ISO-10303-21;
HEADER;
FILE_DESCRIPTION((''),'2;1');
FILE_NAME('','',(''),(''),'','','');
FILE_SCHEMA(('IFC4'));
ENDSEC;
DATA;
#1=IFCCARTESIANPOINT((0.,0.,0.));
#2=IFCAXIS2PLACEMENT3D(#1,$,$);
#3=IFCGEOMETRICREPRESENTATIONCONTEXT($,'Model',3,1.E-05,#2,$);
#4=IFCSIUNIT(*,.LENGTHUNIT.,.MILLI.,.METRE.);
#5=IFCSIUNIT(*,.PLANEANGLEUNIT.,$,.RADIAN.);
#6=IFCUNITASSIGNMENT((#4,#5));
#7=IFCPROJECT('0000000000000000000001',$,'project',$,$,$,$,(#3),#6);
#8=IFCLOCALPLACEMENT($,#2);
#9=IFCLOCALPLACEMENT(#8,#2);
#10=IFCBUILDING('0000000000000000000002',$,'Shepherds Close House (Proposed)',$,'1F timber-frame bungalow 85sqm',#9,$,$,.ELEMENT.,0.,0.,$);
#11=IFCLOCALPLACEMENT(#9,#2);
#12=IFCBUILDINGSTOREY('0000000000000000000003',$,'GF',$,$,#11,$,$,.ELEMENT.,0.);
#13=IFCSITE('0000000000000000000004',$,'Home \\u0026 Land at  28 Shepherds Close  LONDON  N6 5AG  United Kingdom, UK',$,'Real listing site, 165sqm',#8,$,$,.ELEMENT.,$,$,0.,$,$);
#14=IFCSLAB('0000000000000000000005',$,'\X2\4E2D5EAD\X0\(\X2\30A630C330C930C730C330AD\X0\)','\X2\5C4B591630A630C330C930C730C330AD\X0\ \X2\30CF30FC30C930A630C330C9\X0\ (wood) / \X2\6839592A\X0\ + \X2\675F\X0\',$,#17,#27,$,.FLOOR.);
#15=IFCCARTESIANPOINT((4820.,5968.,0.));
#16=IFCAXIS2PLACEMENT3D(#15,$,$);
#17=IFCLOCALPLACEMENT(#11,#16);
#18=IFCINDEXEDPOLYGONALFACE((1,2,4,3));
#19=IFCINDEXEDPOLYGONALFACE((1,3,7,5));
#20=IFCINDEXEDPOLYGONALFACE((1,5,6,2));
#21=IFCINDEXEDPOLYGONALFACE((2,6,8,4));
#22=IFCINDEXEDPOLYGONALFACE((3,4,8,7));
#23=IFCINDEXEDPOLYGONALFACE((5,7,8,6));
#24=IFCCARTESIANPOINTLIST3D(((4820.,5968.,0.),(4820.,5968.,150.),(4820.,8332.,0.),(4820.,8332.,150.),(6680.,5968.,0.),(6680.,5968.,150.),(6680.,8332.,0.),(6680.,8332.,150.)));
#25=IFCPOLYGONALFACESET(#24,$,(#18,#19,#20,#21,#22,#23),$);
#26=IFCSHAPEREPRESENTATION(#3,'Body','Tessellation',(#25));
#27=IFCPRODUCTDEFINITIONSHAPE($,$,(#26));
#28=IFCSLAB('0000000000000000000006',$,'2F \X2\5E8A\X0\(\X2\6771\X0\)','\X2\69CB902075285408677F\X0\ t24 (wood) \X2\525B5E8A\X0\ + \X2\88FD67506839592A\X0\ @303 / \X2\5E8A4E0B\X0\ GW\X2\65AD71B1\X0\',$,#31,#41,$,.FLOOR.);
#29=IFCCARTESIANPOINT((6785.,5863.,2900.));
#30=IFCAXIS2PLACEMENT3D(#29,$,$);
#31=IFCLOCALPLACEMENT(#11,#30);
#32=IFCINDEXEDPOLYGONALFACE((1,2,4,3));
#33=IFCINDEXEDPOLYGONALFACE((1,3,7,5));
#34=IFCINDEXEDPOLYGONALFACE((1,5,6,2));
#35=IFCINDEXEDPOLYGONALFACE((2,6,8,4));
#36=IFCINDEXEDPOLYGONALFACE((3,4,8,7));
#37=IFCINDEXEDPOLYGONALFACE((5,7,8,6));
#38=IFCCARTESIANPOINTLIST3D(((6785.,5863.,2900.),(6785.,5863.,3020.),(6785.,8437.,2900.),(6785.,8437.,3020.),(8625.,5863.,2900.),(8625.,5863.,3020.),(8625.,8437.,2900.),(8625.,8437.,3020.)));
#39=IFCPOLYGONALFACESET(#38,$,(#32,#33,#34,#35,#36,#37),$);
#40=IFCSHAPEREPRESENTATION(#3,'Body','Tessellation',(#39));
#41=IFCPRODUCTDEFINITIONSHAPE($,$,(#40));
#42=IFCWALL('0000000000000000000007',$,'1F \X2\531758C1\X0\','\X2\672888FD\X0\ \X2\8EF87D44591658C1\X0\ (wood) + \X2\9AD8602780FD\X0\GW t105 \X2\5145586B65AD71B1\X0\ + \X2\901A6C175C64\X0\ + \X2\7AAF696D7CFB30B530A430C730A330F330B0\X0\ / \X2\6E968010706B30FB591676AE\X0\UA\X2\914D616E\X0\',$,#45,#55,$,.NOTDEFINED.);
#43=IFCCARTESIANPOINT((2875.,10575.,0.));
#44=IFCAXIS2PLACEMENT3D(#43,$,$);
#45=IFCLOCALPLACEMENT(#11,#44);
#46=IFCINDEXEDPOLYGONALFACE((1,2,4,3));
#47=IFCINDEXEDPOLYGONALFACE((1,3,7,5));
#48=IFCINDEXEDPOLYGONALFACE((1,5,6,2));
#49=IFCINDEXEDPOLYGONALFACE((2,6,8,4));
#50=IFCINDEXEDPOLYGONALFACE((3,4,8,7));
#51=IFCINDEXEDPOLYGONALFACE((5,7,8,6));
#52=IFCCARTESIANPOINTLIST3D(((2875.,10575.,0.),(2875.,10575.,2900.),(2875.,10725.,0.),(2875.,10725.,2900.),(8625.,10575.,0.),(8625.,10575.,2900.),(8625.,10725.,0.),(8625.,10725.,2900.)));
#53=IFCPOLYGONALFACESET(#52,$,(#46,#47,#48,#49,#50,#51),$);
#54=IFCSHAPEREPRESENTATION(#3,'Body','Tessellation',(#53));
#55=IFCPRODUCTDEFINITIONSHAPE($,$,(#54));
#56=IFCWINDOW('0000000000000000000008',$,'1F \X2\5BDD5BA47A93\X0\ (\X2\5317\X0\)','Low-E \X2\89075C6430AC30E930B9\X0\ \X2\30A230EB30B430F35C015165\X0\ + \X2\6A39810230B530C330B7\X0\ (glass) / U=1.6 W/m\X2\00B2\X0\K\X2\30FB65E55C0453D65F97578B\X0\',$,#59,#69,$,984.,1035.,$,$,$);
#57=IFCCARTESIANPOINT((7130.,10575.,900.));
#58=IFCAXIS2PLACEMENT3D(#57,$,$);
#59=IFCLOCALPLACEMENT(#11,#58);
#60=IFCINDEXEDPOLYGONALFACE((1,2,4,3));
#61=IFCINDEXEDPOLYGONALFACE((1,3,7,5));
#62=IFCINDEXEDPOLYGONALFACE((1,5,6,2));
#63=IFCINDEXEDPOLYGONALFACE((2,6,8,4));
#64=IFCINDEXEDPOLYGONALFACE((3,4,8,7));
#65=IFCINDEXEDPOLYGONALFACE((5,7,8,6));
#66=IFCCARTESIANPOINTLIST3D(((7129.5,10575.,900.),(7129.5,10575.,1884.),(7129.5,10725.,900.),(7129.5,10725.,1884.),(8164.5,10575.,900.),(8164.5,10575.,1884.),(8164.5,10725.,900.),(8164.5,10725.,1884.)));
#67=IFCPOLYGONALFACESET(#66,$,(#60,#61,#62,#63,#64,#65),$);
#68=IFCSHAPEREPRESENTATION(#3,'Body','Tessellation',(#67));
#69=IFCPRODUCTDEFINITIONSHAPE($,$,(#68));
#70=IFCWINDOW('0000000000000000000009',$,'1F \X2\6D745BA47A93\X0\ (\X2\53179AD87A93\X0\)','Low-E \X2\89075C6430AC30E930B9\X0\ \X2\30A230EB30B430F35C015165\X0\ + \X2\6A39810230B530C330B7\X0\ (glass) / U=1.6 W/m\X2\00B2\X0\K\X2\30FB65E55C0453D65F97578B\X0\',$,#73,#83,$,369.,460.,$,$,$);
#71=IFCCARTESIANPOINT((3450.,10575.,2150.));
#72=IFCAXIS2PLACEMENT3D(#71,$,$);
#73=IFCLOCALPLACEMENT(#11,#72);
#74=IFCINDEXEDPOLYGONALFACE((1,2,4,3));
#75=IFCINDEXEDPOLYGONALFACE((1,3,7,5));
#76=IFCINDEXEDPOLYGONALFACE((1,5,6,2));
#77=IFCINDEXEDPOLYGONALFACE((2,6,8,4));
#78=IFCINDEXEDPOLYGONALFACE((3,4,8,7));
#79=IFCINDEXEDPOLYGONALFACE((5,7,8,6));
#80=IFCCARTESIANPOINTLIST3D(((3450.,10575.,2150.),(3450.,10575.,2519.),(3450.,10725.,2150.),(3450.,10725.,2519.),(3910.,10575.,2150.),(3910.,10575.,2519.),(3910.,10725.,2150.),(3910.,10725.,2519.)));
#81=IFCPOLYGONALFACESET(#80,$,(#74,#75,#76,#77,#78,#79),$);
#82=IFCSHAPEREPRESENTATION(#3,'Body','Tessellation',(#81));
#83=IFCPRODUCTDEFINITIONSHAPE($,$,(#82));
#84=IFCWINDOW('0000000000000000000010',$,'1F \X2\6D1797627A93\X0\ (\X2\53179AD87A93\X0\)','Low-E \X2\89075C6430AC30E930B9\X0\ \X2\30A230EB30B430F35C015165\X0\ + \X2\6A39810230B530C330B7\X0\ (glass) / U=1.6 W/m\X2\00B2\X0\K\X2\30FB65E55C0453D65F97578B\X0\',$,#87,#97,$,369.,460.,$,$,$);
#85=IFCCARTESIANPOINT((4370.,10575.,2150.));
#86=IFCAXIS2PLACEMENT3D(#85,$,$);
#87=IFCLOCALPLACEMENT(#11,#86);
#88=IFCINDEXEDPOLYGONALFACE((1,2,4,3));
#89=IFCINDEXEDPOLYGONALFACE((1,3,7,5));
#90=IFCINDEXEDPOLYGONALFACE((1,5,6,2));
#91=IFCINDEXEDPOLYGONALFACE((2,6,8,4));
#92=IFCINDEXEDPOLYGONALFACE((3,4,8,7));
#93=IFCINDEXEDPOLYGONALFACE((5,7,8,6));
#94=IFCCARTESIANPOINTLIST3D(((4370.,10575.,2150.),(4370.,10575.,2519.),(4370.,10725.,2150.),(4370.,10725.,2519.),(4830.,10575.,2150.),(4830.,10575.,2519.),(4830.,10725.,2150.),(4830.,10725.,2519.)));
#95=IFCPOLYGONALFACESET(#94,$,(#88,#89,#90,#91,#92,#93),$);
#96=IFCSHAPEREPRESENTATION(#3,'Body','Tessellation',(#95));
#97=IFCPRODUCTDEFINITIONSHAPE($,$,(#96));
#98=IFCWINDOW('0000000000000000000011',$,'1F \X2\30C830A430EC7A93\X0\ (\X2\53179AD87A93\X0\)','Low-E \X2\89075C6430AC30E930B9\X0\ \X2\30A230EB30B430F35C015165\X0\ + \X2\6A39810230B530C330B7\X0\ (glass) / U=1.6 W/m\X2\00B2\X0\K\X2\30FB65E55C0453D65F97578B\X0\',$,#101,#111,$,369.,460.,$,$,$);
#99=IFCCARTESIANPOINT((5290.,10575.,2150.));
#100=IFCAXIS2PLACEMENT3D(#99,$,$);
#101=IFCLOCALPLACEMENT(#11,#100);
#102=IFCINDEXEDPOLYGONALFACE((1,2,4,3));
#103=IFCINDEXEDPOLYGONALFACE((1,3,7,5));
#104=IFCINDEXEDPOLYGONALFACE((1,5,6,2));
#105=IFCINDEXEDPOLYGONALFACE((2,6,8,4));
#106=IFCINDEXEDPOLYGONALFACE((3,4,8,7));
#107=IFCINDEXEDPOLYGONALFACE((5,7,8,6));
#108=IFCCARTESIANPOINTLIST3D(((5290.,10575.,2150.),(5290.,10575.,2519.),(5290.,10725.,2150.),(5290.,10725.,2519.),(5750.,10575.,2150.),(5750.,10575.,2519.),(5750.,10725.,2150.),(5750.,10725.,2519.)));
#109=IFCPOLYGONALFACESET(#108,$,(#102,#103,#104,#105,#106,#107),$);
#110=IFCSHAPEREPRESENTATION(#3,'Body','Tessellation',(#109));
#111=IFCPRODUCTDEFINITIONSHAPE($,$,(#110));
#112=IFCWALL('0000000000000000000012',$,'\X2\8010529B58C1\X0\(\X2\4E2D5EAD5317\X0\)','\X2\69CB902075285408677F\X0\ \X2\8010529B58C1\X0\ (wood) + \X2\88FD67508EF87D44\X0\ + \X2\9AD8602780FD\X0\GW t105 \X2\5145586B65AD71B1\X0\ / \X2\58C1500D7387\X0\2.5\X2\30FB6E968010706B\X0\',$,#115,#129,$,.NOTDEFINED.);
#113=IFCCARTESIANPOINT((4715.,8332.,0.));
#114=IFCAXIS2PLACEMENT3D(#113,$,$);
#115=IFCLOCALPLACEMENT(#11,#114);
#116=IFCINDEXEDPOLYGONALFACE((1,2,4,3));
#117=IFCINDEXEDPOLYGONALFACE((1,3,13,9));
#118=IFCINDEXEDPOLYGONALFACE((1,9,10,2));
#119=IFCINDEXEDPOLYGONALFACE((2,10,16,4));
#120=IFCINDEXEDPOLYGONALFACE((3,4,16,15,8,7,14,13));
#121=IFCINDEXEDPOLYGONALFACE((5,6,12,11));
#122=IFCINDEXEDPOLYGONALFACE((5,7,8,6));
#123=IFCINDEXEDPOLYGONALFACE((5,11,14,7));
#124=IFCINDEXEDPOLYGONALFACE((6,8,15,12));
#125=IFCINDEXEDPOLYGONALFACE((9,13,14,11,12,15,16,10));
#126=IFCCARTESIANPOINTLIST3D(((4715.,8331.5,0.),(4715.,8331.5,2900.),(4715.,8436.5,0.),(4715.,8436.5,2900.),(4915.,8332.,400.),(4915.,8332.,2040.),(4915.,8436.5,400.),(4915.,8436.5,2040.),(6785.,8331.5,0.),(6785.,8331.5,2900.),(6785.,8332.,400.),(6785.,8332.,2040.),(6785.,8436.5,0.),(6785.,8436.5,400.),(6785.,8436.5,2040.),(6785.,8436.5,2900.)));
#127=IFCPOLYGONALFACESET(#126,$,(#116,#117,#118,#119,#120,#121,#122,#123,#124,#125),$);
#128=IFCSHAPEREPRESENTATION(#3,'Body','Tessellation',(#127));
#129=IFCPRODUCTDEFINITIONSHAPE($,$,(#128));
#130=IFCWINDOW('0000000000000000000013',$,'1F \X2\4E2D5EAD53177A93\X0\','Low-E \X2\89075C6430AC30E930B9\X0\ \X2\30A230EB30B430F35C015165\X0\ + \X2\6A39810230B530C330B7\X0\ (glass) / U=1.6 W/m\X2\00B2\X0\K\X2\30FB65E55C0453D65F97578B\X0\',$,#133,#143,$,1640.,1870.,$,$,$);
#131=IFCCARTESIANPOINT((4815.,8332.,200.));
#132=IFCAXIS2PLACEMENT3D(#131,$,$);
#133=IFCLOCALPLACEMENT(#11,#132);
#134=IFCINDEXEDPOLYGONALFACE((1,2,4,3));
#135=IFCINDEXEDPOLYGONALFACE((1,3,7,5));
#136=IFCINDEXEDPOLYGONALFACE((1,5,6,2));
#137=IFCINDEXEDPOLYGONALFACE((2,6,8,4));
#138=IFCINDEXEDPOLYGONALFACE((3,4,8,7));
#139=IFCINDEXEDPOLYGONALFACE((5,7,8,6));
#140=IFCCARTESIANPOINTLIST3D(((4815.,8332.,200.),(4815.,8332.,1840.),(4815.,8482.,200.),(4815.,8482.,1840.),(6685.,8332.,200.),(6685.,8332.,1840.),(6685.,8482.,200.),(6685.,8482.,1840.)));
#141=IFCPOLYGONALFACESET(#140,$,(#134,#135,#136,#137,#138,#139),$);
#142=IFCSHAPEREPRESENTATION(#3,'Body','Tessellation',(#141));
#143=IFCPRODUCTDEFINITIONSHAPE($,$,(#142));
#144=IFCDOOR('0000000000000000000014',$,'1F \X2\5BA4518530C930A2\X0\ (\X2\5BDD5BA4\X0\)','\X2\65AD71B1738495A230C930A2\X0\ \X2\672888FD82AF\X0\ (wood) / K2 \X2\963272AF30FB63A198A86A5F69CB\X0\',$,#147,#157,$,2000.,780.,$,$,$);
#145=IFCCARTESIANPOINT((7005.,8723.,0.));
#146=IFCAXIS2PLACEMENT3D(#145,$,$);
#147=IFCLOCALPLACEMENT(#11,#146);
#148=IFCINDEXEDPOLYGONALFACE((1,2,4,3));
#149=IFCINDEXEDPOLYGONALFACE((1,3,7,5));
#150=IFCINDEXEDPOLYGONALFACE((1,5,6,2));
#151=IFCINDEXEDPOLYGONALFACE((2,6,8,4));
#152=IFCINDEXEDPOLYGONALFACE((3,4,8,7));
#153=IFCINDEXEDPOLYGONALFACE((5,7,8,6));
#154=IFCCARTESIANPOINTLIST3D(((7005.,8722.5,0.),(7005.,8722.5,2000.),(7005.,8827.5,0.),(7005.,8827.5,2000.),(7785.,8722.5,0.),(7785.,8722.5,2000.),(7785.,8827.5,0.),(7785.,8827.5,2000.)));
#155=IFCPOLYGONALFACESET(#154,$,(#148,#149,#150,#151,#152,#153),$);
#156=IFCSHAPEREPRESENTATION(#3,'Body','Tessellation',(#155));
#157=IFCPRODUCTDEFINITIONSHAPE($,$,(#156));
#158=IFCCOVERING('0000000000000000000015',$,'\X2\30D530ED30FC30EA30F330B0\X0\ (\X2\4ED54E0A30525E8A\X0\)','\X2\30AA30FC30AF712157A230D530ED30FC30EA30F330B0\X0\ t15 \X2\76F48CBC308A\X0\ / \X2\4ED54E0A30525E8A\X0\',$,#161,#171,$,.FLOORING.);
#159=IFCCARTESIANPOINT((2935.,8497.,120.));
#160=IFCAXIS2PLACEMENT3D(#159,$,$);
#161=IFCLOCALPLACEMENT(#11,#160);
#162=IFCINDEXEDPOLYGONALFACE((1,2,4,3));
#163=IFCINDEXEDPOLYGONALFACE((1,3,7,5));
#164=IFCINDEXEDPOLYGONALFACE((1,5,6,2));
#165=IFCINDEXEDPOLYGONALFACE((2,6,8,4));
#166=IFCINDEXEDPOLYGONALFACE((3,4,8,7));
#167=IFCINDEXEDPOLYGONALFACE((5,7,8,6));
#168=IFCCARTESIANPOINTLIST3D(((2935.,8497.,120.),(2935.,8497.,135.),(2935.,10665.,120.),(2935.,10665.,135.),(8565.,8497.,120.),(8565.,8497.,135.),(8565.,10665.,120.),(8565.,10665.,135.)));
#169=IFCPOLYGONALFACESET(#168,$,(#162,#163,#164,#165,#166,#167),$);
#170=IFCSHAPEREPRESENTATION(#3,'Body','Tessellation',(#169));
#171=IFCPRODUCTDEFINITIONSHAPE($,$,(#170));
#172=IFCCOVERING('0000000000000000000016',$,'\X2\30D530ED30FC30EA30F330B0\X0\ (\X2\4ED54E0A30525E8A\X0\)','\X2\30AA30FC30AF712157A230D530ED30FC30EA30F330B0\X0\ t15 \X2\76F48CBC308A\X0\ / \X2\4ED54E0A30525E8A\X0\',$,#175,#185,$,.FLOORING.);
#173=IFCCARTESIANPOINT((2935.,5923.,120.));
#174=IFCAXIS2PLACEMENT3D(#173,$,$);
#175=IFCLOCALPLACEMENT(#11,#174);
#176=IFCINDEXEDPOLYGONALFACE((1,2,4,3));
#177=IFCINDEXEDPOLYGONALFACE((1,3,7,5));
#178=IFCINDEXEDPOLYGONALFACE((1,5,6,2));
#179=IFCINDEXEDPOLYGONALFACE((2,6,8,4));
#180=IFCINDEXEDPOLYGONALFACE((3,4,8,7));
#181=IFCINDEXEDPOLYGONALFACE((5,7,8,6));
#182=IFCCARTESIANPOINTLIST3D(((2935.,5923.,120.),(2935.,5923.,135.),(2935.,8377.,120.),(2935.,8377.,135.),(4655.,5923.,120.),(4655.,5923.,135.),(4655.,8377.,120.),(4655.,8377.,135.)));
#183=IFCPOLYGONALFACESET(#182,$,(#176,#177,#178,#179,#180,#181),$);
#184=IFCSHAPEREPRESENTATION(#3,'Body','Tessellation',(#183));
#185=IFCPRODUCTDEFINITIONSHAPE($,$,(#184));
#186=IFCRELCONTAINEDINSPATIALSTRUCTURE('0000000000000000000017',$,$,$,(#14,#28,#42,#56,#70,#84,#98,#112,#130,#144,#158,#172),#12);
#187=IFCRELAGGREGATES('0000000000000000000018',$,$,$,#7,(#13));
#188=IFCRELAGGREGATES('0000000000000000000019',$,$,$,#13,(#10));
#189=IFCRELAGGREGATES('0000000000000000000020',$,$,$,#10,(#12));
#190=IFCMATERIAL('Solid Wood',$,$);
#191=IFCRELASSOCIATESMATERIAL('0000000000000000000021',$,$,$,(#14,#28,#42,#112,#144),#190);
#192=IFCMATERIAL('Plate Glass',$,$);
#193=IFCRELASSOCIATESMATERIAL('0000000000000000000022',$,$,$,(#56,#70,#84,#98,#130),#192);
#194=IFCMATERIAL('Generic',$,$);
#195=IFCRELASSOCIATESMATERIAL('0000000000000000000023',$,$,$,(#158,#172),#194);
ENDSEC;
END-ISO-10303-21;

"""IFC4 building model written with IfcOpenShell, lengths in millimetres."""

from ifc_helpers import new_model, si_unit, frame, frame_2d, origin, place, context, project, spatial, rectangle, extrude, material, element, fill, save


model = new_model("IFC4")

# Units and contexts
model_context = context("Model", 3, precision=1e-05, world=origin())
ifc_project = project(units=[si_unit("LENGTHUNIT", "METRE", prefix="MILLI"), si_unit("PLANEANGLEUNIT", "RADIAN")], contexts=[model_context])

# Site, building, storey
site_placement = place(None, origin())
site = spatial("IfcSite", under=ifc_project, at=site_placement, Name="Home \\u0026 Land at  28 Shepherds Close  LONDON  N6 5AG  United Kingdom, UK", ObjectType="Real listing site, 165sqm", CompositionType="ELEMENT", RefElevation=0.0)
building_placement = place(site_placement, origin())
building = spatial("IfcBuilding", under=site, at=building_placement, Name="Shepherds Close House (Proposed)", ObjectType="1F timber-frame bungalow 85sqm", CompositionType="ELEMENT", ElevationOfRefHeight=0.0, ElevationOfTerrain=0.0)
storey_placement = place(building_placement, origin())
storey = spatial("IfcBuildingStorey", under=building, at=storey_placement, Name="GF", CompositionType="ELEMENT", Elevation=0.0)

# Slabs
ifc_material_1 = material(Name="Solid Wood")
slab_1_placement = place(storey_placement, frame((4820.0, 5968.0, 0.0)))
element("IfcSlab", 1, at=slab_1_placement, inside=storey, material=ifc_material_1, Name="中庭(ウッドデッキ)", Description="屋外ウッドデッキ ハードウッド (wood) / 根太 + 束", PredefinedType="FLOOR", context=model_context, shape_type="SweptSolid", body=[
    extrude(rectangle(XDim=1860.0, YDim=2364.0, at=frame_2d((930.0, 1182.0))), frame((4820.0, 5968.0, 0.0)), (0.0, 0.0, 1.0), 150.0),
])
slab_2_placement = place(storey_placement, frame((6785.0, 5863.0, 2900.0)))
element("IfcSlab", 2, at=slab_2_placement, inside=storey, material=ifc_material_1, Name="2F 床(東)", Description="構造用合板 t24 (wood) 剛床 + 製材根太 @303 / 床下 GW断熱", PredefinedType="FLOOR", context=model_context, shape_type="SweptSolid", body=[
    extrude(rectangle(XDim=1840.0, YDim=2574.0, at=frame_2d((920.0, 1287.0))), frame((6785.0, 5863.0, 2900.0)), (0.0, 0.0, 1.0), 120.0),
])

# Wall, openings, windows
wall_1_placement = place(storey_placement, frame((2875.0, 10575.0, 0.0)))
wall_1 = element("IfcWall", 3, at=wall_1_placement, inside=storey, material=ifc_material_1, Name="1F 北壁", Description="木製 軸組外壁 (wood) + 高性能GW t105 充填断熱 + 通気層 + 窯業系サイディング / 準耐火・外皮UA配慮", PredefinedType="NOTDEFINED", context=model_context, shape_type="SweptSolid", body=[
    extrude(rectangle(XDim=5750.0, YDim=150.0, at=frame_2d((2875.0, 75.0))), frame((2875.0, 10575.0, 0.0)), (0.0, 0.0, 1.0), 2900.0),
])
opening_1_placement = place(storey_placement, frame((7130.0, 10575.0, 900.0)))
opening_1 = element("IfcOpeningElement", 4, at=opening_1_placement, cuts=wall_1, PredefinedType="NOTDEFINED", context=model_context, shape_type="SweptSolid", body=[
    extrude(rectangle(XDim=1035.0, YDim=150.0, at=frame_2d((517.0, 75.0))), frame((7130.0, 10575.0, 900.0)), (0.0, 0.0, 1.0), 984.0),
])
opening_2_placement = place(storey_placement, frame((3450.0, 10575.0, 2150.0)))
opening_2 = element("IfcOpeningElement", 5, at=opening_2_placement, cuts=wall_1, PredefinedType="NOTDEFINED", context=model_context, shape_type="SweptSolid", body=[
    extrude(rectangle(XDim=460.0, YDim=150.0, at=frame_2d((230.0, 75.0))), frame((3450.0, 10575.0, 2150.0)), (0.0, 0.0, 1.0), 369.0),
])
opening_3_placement = place(storey_placement, frame((4370.0, 10575.0, 2150.0)))
opening_3 = element("IfcOpeningElement", 6, at=opening_3_placement, cuts=wall_1, PredefinedType="NOTDEFINED", context=model_context, shape_type="SweptSolid", body=[
    extrude(rectangle(XDim=460.0, YDim=150.0, at=frame_2d((230.0, 75.0))), frame((4370.0, 10575.0, 2150.0)), (0.0, 0.0, 1.0), 369.0),
])
opening_4_placement = place(storey_placement, frame((5290.0, 10575.0, 2150.0)))
opening_4 = element("IfcOpeningElement", 7, at=opening_4_placement, cuts=wall_1, PredefinedType="NOTDEFINED", context=model_context, shape_type="SweptSolid", body=[
    extrude(rectangle(XDim=460.0, YDim=150.0, at=frame_2d((230.0, 75.0))), frame((5290.0, 10575.0, 2150.0)), (0.0, 0.0, 1.0), 369.0),
])
ifc_material_2 = material(Name="Plate Glass")
window_1_placement = place(storey_placement, frame((7130.0, 10575.0, 900.0)))
window_1 = element("IfcWindow", 8, at=window_1_placement, inside=storey, material=ifc_material_2, Name="1F 寝室窓 (北)", Description="Low-E 複層ガラス アルゴン封入 + 樹脂サッシ (glass) / U=1.6 W/m²K・日射取得型", OverallHeight=984.0, OverallWidth=1035.0, context=model_context, shape_type="SweptSolid", body=[
    extrude(rectangle(XDim=1035.0, YDim=150.0, at=frame_2d((517.0, 75.0))), frame((7130.0, 10575.0, 900.0)), (0.0, 0.0, 1.0), 984.0),
])
fill(opening_1, window_1)
window_2_placement = place(storey_placement, frame((3450.0, 10575.0, 2150.0)))
window_2 = element("IfcWindow", 9, at=window_2_placement, inside=storey, material=ifc_material_2, Name="1F 浴室窓 (北高窓)", Description="Low-E 複層ガラス アルゴン封入 + 樹脂サッシ (glass) / U=1.6 W/m²K・日射取得型", OverallHeight=369.0, OverallWidth=460.0, context=model_context, shape_type="SweptSolid", body=[
    extrude(rectangle(XDim=460.0, YDim=150.0, at=frame_2d((230.0, 75.0))), frame((3450.0, 10575.0, 2150.0)), (0.0, 0.0, 1.0), 369.0),
])
fill(opening_2, window_2)
window_3_placement = place(storey_placement, frame((4370.0, 10575.0, 2150.0)))
window_3 = element("IfcWindow", 10, at=window_3_placement, inside=storey, material=ifc_material_2, Name="1F 洗面窓 (北高窓)", Description="Low-E 複層ガラス アルゴン封入 + 樹脂サッシ (glass) / U=1.6 W/m²K・日射取得型", OverallHeight=369.0, OverallWidth=460.0, context=model_context, shape_type="SweptSolid", body=[
    extrude(rectangle(XDim=460.0, YDim=150.0, at=frame_2d((230.0, 75.0))), frame((4370.0, 10575.0, 2150.0)), (0.0, 0.0, 1.0), 369.0),
])
fill(opening_3, window_3)
window_4_placement = place(storey_placement, frame((5290.0, 10575.0, 2150.0)))
window_4 = element("IfcWindow", 11, at=window_4_placement, inside=storey, material=ifc_material_2, Name="1F トイレ窓 (北高窓)", Description="Low-E 複層ガラス アルゴン封入 + 樹脂サッシ (glass) / U=1.6 W/m²K・日射取得型", OverallHeight=369.0, OverallWidth=460.0, context=model_context, shape_type="SweptSolid", body=[
    extrude(rectangle(XDim=460.0, YDim=150.0, at=frame_2d((230.0, 75.0))), frame((5290.0, 10575.0, 2150.0)), (0.0, 0.0, 1.0), 369.0),
])
fill(opening_4, window_4)

# Wall, opening, window
wall_2_placement = place(storey_placement, frame((4715.0, 8332.0, 0.0)))
wall_2 = element("IfcWall", 12, at=wall_2_placement, inside=storey, material=ifc_material_1, Name="耐力壁(中庭北)", Description="構造用合板 耐力壁 (wood) + 製材軸組 + 高性能GW t105 充填断熱 / 壁倍率2.5・準耐火", PredefinedType="NOTDEFINED", context=model_context, shape_type="SweptSolid", body=[
    extrude(rectangle(XDim=2070.0, YDim=105.0, at=frame_2d((1035.0, 52.0))), frame((4715.0, 8332.0, 0.0)), (0.0, 0.0, 1.0), 2900.0),
])
opening_5_placement = place(storey_placement, frame((4815.0, 8332.0, 200.0)))
opening_5 = element("IfcOpeningElement", 13, at=opening_5_placement, cuts=wall_2, PredefinedType="NOTDEFINED", context=model_context, shape_type="SweptSolid", body=[
    extrude(rectangle(XDim=1870.0, YDim=150.0, at=frame_2d((935.0, 75.0))), frame((4815.0, 8332.0, 200.0)), (0.0, 0.0, 1.0), 1640.0),
])
window_5_placement = place(storey_placement, frame((4815.0, 8332.0, 200.0)))
window_5 = element("IfcWindow", 14, at=window_5_placement, inside=storey, material=ifc_material_2, Name="1F 中庭北窓", Description="Low-E 複層ガラス アルゴン封入 + 樹脂サッシ (glass) / U=1.6 W/m²K・日射取得型", OverallHeight=1640.0, OverallWidth=1870.0, context=model_context, shape_type="SweptSolid", body=[
    extrude(rectangle(XDim=1870.0, YDim=150.0, at=frame_2d((935.0, 75.0))), frame((4815.0, 8332.0, 200.0)), (0.0, 0.0, 1.0), 1640.0),
])
fill(opening_5, window_5)

# Door
door_1_placement = place(storey_placement, frame((7005.0, 8723.0, 0.0)))
element("IfcDoor", 15, at=door_1_placement, inside=storey, material=ifc_material_1, Name="1F 室内ドア (寝室)", Description="断熱玄関ドア 木製芯 (wood) / K2 防犯・採風機構", OverallHeight=2000.0, OverallWidth=780.0, context=model_context, shape_type="SweptSolid", body=[
    extrude(rectangle(XDim=780.0, YDim=105.0, at=frame_2d((390.0, 52.0))), frame((7005.0, 8723.0, 0.0)), (0.0, 0.0, 1.0), 2000.0),
])

# Coverings
ifc_material_3 = material(Name="Generic")
covering_1_placement = place(storey_placement, frame((2935.0, 8497.0, 120.0)))
element("IfcCovering", 16, at=covering_1_placement, inside=storey, material=ifc_material_3, Name="フローリング (仕上げ床)", Description="オーク無垢フローリング t15 直貼り / 仕上げ床", PredefinedType="FLOORING", context=model_context, shape_type="SweptSolid", body=[
    extrude(rectangle(XDim=5630.0, YDim=2168.0, at=frame_2d((2815.0, 1084.0))), frame((2935.0, 8497.0, 120.0)), (0.0, 0.0, 1.0), 15.0),
])
covering_2_placement = place(storey_placement, frame((2935.0, 5923.0, 120.0)))
element("IfcCovering", 17, at=covering_2_placement, inside=storey, material=ifc_material_3, Name="フローリング (仕上げ床)", Description="オーク無垢フローリング t15 直貼り / 仕上げ床", PredefinedType="FLOORING", context=model_context, shape_type="SweptSolid", body=[
    extrude(rectangle(XDim=1720.0, YDim=2454.0, at=frame_2d((860.0, 1227.0))), frame((2935.0, 5923.0, 120.0)), (0.0, 0.0, 1.0), 15.0),
])

save(model, "model.ifc")
